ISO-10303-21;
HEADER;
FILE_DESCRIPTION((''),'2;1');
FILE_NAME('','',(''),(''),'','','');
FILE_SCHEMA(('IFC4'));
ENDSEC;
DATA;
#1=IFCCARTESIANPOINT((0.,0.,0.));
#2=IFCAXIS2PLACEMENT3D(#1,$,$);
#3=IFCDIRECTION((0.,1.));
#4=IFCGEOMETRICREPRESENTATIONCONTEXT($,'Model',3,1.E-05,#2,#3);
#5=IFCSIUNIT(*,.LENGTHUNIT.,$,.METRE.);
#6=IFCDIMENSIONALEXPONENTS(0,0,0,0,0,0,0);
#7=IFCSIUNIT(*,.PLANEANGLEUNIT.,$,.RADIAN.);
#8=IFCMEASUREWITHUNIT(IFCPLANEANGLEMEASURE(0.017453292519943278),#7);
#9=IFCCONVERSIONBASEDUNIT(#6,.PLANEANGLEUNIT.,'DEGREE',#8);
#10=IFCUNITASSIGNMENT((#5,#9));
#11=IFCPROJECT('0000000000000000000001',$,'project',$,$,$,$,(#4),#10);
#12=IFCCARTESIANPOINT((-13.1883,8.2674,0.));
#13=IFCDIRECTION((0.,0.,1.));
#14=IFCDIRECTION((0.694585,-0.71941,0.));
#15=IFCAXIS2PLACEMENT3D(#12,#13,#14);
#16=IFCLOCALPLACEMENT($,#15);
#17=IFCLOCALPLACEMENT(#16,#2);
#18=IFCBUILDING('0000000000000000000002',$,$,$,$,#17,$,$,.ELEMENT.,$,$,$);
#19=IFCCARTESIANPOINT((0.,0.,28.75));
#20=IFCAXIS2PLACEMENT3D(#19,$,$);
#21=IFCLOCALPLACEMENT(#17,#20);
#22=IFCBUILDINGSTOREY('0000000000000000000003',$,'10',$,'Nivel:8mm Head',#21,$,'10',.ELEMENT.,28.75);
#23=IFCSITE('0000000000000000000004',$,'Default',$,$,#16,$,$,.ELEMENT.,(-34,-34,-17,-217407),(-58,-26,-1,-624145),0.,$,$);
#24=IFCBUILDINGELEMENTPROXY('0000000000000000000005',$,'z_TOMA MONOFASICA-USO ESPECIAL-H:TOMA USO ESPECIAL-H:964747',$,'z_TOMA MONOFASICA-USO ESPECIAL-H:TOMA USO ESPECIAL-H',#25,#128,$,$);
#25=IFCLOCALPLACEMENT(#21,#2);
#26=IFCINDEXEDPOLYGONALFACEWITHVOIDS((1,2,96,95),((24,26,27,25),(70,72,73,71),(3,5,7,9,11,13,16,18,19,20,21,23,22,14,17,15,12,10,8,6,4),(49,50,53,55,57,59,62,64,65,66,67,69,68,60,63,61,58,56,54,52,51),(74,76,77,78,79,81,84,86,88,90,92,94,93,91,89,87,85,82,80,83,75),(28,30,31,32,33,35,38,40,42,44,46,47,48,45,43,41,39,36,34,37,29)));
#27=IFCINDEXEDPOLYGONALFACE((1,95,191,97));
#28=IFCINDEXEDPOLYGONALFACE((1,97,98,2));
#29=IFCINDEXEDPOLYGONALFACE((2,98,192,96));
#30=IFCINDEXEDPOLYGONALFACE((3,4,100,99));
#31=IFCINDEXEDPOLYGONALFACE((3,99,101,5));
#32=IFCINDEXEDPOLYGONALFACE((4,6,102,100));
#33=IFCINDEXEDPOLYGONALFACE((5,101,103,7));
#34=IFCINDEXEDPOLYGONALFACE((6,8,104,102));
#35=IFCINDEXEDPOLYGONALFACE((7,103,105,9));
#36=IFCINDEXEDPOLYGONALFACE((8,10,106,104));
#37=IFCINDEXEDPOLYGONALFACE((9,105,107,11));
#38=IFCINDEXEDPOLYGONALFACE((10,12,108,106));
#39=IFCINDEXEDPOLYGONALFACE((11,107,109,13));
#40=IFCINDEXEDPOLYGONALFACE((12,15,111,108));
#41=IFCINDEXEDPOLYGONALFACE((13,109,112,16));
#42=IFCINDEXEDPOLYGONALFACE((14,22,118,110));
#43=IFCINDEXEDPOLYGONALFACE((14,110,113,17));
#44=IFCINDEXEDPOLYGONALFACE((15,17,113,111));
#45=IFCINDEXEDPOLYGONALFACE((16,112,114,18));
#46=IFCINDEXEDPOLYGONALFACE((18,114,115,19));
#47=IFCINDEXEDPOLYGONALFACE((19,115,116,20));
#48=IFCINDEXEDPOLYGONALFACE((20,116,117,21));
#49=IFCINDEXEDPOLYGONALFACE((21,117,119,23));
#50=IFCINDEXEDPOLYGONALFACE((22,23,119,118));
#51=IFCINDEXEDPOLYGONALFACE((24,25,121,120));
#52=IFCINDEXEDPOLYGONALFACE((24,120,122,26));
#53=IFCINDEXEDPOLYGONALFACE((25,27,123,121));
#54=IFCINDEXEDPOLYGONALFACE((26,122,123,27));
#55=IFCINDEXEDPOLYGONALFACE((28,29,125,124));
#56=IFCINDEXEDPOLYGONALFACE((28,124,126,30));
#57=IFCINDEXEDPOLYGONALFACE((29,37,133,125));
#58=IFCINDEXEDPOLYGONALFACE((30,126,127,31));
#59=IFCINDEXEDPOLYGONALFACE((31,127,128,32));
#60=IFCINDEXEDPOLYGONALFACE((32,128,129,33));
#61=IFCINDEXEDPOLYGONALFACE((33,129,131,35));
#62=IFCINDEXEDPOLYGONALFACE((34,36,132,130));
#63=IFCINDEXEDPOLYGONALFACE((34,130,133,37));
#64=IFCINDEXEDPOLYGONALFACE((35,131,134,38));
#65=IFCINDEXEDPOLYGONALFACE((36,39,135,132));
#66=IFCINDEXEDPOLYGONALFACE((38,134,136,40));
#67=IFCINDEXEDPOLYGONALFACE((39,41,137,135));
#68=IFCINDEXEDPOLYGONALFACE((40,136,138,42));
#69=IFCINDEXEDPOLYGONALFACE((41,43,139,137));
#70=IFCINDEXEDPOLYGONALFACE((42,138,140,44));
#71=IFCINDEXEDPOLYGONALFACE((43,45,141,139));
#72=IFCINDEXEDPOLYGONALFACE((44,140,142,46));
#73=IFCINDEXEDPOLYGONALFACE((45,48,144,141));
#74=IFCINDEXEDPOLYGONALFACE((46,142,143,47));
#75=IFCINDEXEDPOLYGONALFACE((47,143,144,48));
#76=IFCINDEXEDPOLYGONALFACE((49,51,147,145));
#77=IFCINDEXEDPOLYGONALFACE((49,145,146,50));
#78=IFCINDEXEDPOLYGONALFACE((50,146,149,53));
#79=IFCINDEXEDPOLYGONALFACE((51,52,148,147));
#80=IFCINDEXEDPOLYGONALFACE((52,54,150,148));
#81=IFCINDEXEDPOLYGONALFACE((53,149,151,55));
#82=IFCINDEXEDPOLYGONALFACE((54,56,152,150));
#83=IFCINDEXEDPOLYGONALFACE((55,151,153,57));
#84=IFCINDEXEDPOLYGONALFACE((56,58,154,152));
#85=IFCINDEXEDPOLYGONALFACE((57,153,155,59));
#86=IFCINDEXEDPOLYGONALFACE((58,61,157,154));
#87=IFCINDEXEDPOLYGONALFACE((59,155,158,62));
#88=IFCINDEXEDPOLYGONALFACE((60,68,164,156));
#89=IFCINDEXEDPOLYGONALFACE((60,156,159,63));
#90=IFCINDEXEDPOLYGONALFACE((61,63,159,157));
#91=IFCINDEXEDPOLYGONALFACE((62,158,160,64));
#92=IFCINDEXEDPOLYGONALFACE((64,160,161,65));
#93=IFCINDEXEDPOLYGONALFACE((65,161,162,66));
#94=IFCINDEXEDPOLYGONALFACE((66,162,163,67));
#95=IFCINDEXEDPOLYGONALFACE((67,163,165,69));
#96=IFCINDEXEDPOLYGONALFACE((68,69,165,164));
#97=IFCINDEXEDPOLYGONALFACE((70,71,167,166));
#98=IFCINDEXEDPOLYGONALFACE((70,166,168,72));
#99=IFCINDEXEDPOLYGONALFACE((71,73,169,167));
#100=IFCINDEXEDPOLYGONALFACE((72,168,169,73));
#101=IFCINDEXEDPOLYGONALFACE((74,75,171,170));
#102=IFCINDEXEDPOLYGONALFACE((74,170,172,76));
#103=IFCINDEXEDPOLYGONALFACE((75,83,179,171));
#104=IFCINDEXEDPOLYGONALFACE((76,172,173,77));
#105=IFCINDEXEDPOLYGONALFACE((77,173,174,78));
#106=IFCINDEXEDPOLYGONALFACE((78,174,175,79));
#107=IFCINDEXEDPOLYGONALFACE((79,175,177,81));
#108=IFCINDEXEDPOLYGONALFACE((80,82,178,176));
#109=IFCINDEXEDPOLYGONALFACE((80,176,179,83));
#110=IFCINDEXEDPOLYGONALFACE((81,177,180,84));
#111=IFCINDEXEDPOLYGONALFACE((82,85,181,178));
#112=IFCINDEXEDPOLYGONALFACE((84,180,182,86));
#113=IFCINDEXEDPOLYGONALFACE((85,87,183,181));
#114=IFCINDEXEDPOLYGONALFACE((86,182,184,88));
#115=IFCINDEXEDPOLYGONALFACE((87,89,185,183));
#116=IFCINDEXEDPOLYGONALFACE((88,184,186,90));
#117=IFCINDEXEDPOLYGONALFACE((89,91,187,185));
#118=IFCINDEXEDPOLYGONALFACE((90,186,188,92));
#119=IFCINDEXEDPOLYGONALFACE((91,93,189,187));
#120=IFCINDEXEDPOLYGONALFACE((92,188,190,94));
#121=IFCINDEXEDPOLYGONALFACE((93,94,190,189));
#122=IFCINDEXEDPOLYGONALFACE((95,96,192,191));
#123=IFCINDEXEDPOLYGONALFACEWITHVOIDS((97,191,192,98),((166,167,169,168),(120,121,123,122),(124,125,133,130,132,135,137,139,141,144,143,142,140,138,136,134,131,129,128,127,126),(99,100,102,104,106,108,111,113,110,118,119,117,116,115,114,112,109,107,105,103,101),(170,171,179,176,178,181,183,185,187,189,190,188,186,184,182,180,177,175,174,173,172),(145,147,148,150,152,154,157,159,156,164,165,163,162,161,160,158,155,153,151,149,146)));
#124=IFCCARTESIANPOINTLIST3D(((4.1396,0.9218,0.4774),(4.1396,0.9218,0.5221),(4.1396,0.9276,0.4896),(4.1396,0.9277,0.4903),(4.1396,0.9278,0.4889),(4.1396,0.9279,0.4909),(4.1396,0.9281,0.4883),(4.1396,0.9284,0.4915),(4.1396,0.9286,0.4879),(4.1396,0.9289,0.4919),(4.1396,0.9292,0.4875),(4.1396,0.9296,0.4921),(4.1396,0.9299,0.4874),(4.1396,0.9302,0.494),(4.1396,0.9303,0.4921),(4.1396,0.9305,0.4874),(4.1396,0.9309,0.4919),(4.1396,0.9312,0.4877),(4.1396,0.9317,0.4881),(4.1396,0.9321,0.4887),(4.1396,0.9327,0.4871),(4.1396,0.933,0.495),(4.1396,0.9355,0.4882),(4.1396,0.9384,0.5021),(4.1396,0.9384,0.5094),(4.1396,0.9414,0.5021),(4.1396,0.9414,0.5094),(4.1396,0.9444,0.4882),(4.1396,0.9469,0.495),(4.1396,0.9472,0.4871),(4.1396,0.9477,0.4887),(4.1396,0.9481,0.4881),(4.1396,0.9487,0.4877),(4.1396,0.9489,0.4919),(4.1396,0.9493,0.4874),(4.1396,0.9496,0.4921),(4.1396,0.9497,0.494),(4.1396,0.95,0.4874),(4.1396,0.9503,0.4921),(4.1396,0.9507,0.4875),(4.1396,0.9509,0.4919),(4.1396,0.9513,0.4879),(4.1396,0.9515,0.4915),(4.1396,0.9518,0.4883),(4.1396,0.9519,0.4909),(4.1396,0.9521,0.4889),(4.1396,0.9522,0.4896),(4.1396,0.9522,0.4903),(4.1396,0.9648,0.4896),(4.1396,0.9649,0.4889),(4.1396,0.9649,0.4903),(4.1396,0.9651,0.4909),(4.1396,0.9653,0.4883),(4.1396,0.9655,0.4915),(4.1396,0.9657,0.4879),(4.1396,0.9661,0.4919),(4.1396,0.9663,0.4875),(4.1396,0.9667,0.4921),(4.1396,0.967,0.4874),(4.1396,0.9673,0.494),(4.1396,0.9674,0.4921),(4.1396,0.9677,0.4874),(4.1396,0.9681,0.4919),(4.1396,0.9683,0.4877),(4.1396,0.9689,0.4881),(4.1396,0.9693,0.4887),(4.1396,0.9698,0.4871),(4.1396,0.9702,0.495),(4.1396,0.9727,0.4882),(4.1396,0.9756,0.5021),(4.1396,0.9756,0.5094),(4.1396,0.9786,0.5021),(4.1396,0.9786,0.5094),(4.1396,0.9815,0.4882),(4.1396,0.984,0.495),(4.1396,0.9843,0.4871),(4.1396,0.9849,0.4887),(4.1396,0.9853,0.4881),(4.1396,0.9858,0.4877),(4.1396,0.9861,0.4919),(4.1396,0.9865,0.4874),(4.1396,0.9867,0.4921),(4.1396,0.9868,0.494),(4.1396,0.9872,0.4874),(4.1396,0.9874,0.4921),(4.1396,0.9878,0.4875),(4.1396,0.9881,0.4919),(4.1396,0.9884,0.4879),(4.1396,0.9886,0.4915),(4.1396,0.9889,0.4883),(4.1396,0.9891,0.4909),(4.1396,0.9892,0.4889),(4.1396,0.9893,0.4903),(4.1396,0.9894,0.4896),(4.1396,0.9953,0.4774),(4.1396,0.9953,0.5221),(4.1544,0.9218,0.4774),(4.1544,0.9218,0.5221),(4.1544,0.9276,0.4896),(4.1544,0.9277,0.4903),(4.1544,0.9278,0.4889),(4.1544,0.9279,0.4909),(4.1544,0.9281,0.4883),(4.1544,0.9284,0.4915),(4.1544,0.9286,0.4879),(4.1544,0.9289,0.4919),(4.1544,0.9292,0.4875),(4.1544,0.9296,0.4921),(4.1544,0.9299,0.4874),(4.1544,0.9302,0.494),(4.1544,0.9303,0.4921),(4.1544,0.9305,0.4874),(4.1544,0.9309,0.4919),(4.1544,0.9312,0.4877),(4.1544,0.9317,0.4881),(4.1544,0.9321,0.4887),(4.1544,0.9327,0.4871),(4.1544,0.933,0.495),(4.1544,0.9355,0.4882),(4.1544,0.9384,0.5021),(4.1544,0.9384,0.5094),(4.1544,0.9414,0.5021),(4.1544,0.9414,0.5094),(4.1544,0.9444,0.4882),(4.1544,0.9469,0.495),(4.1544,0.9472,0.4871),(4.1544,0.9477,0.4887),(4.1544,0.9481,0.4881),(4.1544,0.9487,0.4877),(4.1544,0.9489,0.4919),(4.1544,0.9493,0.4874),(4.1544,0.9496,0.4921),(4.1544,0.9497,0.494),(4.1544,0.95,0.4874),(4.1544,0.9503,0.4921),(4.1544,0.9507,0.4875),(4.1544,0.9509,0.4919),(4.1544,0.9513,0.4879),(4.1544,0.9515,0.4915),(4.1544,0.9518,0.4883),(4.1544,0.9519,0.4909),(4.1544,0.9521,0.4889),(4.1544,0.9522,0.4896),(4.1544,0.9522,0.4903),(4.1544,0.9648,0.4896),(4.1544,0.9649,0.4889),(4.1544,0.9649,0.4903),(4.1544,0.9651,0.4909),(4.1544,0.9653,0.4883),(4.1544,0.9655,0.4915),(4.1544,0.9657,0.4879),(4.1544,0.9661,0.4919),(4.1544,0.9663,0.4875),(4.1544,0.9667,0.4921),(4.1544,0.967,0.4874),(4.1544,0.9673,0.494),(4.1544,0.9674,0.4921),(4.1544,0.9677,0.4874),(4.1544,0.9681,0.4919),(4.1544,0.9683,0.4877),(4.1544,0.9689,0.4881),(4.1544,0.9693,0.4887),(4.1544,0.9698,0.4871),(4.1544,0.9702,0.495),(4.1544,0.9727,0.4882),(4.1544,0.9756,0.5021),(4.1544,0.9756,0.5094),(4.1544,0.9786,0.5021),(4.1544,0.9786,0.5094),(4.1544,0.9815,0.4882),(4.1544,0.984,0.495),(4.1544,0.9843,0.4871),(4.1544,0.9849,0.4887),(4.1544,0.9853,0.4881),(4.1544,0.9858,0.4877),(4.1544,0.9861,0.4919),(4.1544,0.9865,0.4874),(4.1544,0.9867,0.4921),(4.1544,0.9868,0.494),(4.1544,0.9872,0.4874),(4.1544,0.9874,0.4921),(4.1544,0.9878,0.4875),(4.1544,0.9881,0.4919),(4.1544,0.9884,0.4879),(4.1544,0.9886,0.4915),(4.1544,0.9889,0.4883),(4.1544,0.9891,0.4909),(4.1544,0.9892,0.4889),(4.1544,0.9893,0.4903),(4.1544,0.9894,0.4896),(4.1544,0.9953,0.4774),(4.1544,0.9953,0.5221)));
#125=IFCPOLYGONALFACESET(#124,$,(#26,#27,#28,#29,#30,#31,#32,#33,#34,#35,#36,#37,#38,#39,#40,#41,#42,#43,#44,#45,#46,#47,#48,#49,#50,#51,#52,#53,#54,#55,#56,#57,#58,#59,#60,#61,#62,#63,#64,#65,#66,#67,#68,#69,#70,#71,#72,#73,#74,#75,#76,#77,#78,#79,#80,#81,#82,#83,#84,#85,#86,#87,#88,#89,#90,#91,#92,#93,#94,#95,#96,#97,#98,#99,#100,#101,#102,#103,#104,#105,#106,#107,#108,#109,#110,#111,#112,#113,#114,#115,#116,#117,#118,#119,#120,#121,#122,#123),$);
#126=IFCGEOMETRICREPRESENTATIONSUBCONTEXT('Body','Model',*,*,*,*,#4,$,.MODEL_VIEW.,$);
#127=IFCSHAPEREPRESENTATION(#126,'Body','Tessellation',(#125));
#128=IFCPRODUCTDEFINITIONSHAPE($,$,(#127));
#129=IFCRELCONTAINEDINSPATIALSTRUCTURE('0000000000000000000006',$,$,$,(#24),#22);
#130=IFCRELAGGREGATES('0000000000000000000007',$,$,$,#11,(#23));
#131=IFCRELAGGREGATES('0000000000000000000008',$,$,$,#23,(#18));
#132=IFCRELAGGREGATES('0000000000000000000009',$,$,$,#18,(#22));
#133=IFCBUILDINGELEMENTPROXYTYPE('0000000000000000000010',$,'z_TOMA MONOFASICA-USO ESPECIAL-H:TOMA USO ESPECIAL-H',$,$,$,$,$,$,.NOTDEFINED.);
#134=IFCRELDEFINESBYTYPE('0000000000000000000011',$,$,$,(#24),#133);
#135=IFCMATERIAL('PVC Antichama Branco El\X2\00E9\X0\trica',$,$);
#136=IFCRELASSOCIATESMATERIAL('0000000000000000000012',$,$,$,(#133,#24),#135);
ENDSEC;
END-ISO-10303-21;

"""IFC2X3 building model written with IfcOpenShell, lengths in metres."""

from ifc_helpers import new_model, entity, si_unit, converted_unit, direction, frame, frame_2d, origin, place, context, subcontext, project, spatial, polyline, circle_curve, parameter, trimmed, segment, composite_curve, outline, extrude, source, transform, mapped, material, type_object, type_shapes, element, save


model = new_model("IFC2X3")

# Units and contexts
model_context = context("Model", 3, precision=1e-05, world=origin(), true_north=direction((0.0, 1.0)))
body_context = subcontext(model_context, "Body", "Model", "MODEL_VIEW")
ifc_project = project(units=[si_unit("LENGTHUNIT", "METRE"), converted_unit("PLANEANGLEUNIT", "DEGREE", entity("IfcPlaneAngleMeasure", 0.017453292519943278), si_unit("PLANEANGLEUNIT", "RADIAN"), dimensions=[0, 0, 0, 0, 0, 0, 0])], contexts=[model_context])

# Site, building, storey
site_placement = place(None, frame((-13.1883, 8.2674, 0.0), z_axis=(0.0, 0.0, 1.0), x_axis=(0.694585, -0.71941, 0.0)))
site = spatial("IfcSite", under=ifc_project, at=site_placement, Name="Default", CompositionType="ELEMENT", RefLatitude=(-34, -34, -17, -217407), RefLongitude=(-58, -26, -1, -624145), RefElevation=0.0)
building_placement = place(site_placement, origin())
building = spatial("IfcBuilding", under=site, at=building_placement, CompositionType="ELEMENT")
storey_placement = place(building_placement, frame((0.0, 0.0, 28.75)))
storey = spatial("IfcBuildingStorey", under=building, at=storey_placement, Name="10", ObjectType="Nivel:8mm Head", LongName="10", CompositionType="ELEMENT", Elevation=28.75)

# Building element proxy
ifc_material_1 = material(Name="PVC Antichama Branco Elétrica")
building_element_proxy_type_1 = type_object("IfcBuildingElementProxyType", Name="z_TOMA MONOFASICA-USO ESPECIAL-H:TOMA USO ESPECIAL-H", PredefinedType="NOTDEFINED", material=ifc_material_1)
shared_shape_1 = source(origin(), body_context, "Body", "SweptSolid", [
    extrude(outline(polyline([(-0.0368, -0.0223), (0.0368, -0.0223), (0.0368, 0.0223), (-0.0368, 0.0223), (-0.0368, -0.0223)]), holes=[composite_curve([segment(polyline([(0.0141, 0.0115), (0.0116, 0.0047)]), True, "CONTINUOUS"), segment(polyline([(0.0116, 0.0047), (0.0088, 0.0057)]), True, "CONTINUOUS"), segment(polyline([(0.0088, 0.0057), (0.0096, 0.0078)]), True, "CONTINUOUS"), segment(trimmed(circle_curve(frame_2d((0.0087, 0.0099), x_axis=(1.0, 0.0)), 0.0024), [parameter(27.118901)], [parameter(292.881099)], True, "PARAMETER"), False, "CONTINUOUS"), segment(polyline([(0.0108, 0.011), (0.0113, 0.0126)]), True, "CONTINUOUS"), segment(polyline([(0.0113, 0.0126), (0.0141, 0.0115)]), True, "CONTINUOUS")], self_intersect=False), composite_curve([segment(polyline([(0.0255, 0.0047), (0.023, 0.0115)]), True, "CONTINUOUS"), segment(polyline([(0.023, 0.0115), (0.0258, 0.0126)]), True, "CONTINUOUS"), segment(polyline([(0.0258, 0.0126), (0.0264, 0.011)]), True, "CONTINUOUS"), segment(trimmed(circle_curve(frame_2d((0.0285, 0.0099), x_axis=(1.0, 0.0)), 0.0024), [parameter(247.118901)], [parameter(152.881099)], True, "PARAMETER"), False, "CONTINUOUS"), segment(polyline([(0.0276, 0.0078), (0.0283, 0.0057)]), True, "CONTINUOUS"), segment(polyline([(0.0283, 0.0057), (0.0255, 0.0047)]), True, "CONTINUOUS")], self_intersect=False), polyline([(0.0201, -0.0024), (0.0201, -0.0097), (0.0171, -0.0097), (0.0171, -0.0024), (0.0201, -0.0024)]), composite_curve([segment(polyline([(-0.0141, 0.0115), (-0.0113, 0.0126)]), True, "CONTINUOUS"), segment(polyline([(-0.0113, 0.0126), (-0.0108, 0.011)]), True, "CONTINUOUS"), segment(trimmed(circle_curve(frame_2d((-0.0087, 0.0099), x_axis=(1.0, 0.0)), 0.0024), [parameter(247.118901)], [parameter(152.881099)], True, "PARAMETER"), False, "CONTINUOUS"), segment(polyline([(-0.0096, 0.0078), (-0.0088, 0.0057)]), True, "CONTINUOUS"), segment(polyline([(-0.0088, 0.0057), (-0.0116, 0.0047)]), True, "CONTINUOUS"), segment(polyline([(-0.0116, 0.0047), (-0.0141, 0.0115)]), True, "CONTINUOUS")], self_intersect=False), composite_curve([segment(polyline([(-0.0255, 0.0047), (-0.0283, 0.0057)]), True, "CONTINUOUS"), segment(polyline([(-0.0283, 0.0057), (-0.0276, 0.0078)]), True, "CONTINUOUS"), segment(trimmed(circle_curve(frame_2d((-0.0285, 0.0099), x_axis=(1.0, 0.0)), 0.0024), [parameter(27.118901)], [parameter(292.881099)], True, "PARAMETER"), False, "CONTINUOUS"), segment(polyline([(-0.0264, 0.011), (-0.0258, 0.0126)]), True, "CONTINUOUS"), segment(polyline([(-0.0258, 0.0126), (-0.023, 0.0115)]), True, "CONTINUOUS"), segment(polyline([(-0.023, 0.0115), (-0.0255, 0.0047)]), True, "CONTINUOUS")], self_intersect=False), polyline([(-0.0201, -0.0024), (-0.0171, -0.0024), (-0.0171, -0.0097), (-0.0201, -0.0097), (-0.0201, -0.0024)])]), frame((0.0, -0.005, 0.0223), z_axis=(0.0, 1.0, 0.0), x_axis=(1.0, 0.0, 0.0)), (0.0, 0.0, 1.0), 0.0148),
])
type_shapes(building_element_proxy_type_1, [shared_shape_1])
for number, where, z_axis, x_axis, name in (
    (1, (4.1446, 0.9585, 0.4774), (0.0, 0.0, 1.0), (0.0, -1.0, 0.0), "z_TOMA MONOFASICA-USO ESPECIAL-H:TOMA USO ESPECIAL-H:964747"),
):
    element("IfcBuildingElementProxy", number, at=place(storey_placement, frame(where, z_axis=z_axis, x_axis=x_axis)), inside=storey, type_object=building_element_proxy_type_1, material=ifc_material_1, Name=name, ObjectType="z_TOMA MONOFASICA-USO ESPECIAL-H:TOMA USO ESPECIAL-H", context=body_context, shape_type="MappedRepresentation", body=[
        mapped(shared_shape_1, transform((0.0, 0.0, 0.0), scale=1.0)),
    ])

save(model, "model.ifc")
